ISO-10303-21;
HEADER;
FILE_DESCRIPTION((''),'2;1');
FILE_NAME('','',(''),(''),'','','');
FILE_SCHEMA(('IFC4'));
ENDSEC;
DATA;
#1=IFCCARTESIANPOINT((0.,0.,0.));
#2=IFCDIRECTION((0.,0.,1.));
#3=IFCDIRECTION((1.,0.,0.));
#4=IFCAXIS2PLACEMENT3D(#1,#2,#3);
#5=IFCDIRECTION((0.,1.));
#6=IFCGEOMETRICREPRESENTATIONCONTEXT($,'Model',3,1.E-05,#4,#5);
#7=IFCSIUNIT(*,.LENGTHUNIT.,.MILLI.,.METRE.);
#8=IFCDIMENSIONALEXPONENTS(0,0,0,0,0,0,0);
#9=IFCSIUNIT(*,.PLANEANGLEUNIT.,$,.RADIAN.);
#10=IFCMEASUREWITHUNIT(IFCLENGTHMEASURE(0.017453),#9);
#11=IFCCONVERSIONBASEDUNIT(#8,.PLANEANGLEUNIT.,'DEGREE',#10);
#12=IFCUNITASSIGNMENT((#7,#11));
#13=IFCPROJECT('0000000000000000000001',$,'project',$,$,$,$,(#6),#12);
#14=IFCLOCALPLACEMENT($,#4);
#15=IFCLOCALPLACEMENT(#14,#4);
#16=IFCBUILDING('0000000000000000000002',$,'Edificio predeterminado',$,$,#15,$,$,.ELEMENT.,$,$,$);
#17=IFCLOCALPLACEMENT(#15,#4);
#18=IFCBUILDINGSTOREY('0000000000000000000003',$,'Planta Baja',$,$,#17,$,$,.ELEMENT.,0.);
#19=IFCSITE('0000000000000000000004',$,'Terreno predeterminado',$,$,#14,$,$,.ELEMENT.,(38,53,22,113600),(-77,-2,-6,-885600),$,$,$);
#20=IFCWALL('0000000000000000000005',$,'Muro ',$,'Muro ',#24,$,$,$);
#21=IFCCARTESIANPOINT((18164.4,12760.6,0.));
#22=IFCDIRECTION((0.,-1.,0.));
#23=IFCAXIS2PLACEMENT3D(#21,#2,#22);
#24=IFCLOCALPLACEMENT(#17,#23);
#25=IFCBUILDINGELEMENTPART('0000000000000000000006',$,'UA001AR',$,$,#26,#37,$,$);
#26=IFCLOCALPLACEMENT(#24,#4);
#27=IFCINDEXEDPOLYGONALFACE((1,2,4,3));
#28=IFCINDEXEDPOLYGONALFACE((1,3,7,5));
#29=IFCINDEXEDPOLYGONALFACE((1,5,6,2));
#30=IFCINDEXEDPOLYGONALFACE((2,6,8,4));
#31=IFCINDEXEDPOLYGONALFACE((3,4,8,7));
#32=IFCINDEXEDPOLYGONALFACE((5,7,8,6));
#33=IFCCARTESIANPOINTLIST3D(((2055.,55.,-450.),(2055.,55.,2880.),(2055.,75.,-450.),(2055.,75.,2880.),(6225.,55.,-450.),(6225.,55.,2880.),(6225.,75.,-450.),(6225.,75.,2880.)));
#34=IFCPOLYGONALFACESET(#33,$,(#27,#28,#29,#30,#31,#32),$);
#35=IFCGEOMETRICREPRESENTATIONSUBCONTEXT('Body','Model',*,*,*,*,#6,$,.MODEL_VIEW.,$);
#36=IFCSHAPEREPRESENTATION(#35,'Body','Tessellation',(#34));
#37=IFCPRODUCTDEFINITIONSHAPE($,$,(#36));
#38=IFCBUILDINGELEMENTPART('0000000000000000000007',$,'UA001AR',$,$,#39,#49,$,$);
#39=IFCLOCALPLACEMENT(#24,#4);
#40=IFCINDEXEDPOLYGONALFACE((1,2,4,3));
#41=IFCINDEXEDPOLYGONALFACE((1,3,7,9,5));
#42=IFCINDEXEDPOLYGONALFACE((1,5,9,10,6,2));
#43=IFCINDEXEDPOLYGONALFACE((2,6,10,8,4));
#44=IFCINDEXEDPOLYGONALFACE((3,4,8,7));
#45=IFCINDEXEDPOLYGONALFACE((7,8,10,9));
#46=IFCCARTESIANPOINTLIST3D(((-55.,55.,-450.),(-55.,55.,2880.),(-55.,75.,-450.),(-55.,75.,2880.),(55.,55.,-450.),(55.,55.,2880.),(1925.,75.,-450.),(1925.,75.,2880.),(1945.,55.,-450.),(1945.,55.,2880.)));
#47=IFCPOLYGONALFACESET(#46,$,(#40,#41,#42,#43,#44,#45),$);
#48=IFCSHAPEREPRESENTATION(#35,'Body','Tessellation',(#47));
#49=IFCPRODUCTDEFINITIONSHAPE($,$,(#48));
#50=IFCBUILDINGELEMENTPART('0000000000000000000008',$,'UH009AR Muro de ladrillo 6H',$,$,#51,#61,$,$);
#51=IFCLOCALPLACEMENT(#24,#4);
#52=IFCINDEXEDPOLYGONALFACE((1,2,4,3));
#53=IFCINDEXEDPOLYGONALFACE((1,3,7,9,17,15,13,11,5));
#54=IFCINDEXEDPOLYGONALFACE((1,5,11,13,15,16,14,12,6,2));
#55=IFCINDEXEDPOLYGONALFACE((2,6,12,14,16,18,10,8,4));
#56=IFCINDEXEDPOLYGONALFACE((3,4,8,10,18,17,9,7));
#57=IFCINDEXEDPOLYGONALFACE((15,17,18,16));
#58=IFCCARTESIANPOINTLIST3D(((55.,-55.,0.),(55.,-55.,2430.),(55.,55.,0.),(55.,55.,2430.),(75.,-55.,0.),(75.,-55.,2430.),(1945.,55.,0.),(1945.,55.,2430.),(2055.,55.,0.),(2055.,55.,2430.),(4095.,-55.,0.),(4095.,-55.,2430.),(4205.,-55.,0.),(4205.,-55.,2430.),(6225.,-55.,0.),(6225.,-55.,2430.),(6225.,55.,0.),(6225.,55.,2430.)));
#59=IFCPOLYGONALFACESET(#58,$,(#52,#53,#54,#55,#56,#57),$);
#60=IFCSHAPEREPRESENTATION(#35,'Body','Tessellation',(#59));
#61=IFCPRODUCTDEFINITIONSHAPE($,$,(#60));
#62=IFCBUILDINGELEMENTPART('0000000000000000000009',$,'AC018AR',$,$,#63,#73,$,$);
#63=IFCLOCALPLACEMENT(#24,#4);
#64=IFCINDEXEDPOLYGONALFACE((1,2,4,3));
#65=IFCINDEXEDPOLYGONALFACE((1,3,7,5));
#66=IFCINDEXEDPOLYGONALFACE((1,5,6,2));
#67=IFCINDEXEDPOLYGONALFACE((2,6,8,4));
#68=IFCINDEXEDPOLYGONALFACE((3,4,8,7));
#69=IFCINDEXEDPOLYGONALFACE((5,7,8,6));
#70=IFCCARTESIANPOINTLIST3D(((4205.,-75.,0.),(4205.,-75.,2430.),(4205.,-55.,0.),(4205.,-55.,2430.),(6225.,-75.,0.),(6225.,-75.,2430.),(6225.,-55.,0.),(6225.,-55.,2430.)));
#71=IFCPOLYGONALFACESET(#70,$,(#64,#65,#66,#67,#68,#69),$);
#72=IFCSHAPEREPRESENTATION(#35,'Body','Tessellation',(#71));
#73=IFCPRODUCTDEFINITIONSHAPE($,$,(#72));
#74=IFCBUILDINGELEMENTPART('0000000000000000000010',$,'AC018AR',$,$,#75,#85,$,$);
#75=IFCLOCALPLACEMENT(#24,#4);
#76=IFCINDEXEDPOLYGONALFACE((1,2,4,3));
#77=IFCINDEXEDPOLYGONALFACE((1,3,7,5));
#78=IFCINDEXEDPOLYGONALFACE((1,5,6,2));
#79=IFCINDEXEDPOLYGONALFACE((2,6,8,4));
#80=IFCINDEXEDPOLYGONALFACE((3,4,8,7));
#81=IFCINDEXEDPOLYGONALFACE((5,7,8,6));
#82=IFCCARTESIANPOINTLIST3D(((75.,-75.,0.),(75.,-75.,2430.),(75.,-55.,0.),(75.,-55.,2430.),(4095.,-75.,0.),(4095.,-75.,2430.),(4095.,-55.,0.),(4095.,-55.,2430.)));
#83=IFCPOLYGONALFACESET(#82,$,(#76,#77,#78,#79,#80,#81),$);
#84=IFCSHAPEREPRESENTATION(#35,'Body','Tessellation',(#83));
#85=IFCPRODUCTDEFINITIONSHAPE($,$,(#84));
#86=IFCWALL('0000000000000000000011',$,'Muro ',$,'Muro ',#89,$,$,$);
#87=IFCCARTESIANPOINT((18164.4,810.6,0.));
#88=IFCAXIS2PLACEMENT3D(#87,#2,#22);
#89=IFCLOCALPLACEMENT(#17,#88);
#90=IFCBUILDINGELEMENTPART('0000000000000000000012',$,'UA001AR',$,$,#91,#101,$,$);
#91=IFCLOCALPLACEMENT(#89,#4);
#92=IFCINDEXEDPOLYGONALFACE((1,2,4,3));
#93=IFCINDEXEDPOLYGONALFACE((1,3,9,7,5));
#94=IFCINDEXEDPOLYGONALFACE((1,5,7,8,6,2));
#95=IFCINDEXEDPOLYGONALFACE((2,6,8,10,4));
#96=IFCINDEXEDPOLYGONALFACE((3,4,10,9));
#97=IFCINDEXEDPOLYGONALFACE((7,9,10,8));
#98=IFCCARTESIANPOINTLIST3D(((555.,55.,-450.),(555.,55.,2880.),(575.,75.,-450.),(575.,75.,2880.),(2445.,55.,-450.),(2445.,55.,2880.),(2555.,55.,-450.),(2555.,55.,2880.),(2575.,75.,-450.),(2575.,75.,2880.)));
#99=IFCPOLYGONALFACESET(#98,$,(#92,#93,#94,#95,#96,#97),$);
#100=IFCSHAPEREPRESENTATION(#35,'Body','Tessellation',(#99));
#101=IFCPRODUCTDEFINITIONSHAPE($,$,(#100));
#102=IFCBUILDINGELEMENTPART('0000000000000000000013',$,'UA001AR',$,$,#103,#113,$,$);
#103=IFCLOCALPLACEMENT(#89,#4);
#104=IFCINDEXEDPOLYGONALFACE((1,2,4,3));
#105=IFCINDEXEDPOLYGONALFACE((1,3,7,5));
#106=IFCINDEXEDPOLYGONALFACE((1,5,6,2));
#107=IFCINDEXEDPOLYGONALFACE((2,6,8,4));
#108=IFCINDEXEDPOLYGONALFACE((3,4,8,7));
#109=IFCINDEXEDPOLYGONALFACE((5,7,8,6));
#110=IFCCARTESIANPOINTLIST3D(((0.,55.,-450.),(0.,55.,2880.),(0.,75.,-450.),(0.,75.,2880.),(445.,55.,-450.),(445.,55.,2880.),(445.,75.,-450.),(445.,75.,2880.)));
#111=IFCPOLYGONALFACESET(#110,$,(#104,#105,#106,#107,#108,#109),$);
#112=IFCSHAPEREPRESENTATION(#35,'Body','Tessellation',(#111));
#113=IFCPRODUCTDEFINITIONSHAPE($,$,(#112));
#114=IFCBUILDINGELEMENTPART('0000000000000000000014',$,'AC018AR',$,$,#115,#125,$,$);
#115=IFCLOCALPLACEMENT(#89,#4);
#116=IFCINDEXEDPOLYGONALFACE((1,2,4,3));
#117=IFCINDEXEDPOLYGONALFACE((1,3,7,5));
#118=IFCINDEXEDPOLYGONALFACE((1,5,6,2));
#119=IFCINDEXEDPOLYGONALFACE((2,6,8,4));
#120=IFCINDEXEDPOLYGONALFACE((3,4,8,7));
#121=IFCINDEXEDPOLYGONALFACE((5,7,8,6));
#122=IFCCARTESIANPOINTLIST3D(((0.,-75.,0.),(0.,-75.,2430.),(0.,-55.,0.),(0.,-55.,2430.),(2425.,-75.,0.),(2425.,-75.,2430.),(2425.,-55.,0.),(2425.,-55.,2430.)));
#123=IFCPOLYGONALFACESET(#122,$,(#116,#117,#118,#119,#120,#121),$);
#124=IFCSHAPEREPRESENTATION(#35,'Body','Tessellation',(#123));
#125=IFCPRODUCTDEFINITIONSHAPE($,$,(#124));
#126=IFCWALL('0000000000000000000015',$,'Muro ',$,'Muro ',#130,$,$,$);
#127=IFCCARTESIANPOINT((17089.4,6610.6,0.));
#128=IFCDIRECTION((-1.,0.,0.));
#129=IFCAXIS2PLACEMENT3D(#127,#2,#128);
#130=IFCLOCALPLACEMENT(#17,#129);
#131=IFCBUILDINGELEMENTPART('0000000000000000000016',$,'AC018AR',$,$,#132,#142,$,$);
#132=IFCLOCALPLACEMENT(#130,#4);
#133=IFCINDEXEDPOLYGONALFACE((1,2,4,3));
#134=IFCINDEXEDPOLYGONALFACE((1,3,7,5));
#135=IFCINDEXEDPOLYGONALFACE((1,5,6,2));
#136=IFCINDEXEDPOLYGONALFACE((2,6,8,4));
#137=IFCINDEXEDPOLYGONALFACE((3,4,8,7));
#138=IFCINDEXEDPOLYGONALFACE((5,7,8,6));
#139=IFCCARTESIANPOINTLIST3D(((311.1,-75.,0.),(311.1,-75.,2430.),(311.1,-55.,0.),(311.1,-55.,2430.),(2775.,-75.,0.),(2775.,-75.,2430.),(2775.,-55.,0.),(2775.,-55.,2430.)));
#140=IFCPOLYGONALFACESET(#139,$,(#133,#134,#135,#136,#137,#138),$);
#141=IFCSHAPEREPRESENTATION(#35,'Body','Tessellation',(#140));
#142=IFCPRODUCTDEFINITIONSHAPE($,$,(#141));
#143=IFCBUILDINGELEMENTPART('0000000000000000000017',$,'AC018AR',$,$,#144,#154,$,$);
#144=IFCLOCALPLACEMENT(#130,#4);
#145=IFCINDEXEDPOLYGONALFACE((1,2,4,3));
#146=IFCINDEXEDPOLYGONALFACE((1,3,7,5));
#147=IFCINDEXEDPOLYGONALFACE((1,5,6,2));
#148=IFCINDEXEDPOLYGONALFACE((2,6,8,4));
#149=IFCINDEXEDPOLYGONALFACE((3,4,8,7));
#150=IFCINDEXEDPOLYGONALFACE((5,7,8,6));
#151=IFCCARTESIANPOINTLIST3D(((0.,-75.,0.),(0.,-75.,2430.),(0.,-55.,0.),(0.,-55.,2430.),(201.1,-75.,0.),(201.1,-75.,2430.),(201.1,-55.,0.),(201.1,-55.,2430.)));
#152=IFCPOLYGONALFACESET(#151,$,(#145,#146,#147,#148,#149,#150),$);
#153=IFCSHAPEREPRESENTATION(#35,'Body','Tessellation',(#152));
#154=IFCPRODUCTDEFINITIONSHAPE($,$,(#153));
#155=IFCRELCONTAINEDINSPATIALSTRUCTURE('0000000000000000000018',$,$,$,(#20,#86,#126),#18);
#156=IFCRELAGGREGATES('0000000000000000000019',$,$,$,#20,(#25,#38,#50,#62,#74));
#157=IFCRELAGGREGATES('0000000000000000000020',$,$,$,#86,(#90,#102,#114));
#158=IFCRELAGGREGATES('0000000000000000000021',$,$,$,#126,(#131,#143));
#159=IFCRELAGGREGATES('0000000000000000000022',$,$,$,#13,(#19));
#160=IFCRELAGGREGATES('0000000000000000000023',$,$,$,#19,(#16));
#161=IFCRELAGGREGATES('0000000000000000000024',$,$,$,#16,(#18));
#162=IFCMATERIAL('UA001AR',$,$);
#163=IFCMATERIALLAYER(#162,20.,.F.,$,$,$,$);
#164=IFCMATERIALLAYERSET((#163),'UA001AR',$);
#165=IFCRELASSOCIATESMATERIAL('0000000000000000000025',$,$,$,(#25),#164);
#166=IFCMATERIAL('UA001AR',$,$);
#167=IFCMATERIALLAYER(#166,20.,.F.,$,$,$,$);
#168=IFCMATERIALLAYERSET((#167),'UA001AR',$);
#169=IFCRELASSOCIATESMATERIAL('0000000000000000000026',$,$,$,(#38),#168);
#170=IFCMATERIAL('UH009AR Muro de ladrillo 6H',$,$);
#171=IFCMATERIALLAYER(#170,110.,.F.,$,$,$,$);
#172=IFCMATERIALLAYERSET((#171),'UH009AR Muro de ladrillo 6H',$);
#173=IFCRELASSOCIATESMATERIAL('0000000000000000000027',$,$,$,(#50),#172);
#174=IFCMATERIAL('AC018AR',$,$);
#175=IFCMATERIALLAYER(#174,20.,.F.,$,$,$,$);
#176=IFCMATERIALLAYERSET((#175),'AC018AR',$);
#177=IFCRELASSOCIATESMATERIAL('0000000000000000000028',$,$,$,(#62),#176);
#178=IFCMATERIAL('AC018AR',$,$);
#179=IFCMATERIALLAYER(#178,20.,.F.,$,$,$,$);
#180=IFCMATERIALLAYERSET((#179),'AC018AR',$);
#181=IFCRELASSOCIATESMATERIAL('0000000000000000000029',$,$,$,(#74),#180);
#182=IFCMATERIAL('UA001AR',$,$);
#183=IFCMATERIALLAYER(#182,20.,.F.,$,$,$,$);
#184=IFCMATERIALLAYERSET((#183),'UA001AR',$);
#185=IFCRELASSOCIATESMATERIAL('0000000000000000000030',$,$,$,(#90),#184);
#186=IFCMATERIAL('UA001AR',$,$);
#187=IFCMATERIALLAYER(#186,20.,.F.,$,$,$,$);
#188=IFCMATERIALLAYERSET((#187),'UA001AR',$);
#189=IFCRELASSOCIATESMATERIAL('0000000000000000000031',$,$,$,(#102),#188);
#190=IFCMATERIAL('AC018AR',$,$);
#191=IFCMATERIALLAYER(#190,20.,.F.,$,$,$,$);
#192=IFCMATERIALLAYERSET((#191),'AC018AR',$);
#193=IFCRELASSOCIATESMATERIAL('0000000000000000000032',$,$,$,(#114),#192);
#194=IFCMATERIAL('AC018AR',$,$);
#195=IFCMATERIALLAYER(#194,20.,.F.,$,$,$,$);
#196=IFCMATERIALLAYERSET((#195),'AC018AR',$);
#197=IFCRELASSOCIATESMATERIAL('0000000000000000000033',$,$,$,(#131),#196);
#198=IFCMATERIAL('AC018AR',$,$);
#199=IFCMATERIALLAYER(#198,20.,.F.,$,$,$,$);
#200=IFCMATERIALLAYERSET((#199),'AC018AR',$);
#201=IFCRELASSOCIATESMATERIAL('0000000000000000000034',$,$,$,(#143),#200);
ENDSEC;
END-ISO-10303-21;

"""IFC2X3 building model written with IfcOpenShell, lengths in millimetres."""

from ifc_helpers import new_model, entity, si_unit, converted_unit, direction, frame, origin_with_axes, place, context, subcontext, project, spatial, polyline, outline, extrude, material, layer, layer_set, layer_usage, element, aggregate, save


model = new_model("IFC2X3")

# Units and contexts
model_context = context("Model", 3, precision=1e-05, world=origin_with_axes(), true_north=direction((0.0, 1.0)))
body_context = subcontext(model_context, "Body", "Model", "MODEL_VIEW")
ifc_project = project(units=[si_unit("LENGTHUNIT", "METRE", prefix="MILLI"), converted_unit("PLANEANGLEUNIT", "DEGREE", entity("IfcLengthMeasure", 0.017453), si_unit("PLANEANGLEUNIT", "RADIAN"), dimensions=[0, 0, 0, 0, 0, 0, 0])], contexts=[model_context])

# Site, building, storey
site_placement = place(None, origin_with_axes())
site = spatial("IfcSite", under=ifc_project, at=site_placement, Name="Terreno predeterminado", CompositionType="ELEMENT", RefLatitude=(38, 53, 22, 113600), RefLongitude=(-77, -2, -6, -885600))
building_placement = place(site_placement, origin_with_axes())
building = spatial("IfcBuilding", under=site, at=building_placement, Name="Edificio predeterminado", CompositionType="ELEMENT")
storey_placement = place(building_placement, origin_with_axes())
storey = spatial("IfcBuildingStorey", under=building, at=storey_placement, Name="Planta Baja", CompositionType="ELEMENT", Elevation=0.0)

# Walls, building element parts
wall_1_placement = place(storey_placement, frame((18164.4, 12760.6, 0.0), z_axis=(0.0, 0.0, 1.0), x_axis=(0.0, -1.0, 0.0)))
wall_1 = element("IfcWall", 1, at=wall_1_placement, inside=storey, Name="Muro ", ObjectType="Muro ")
ifc_material_1 = material(Name="UA001AR")
ifc_layer_1 = layer(ifc_material_1, 20.0, ventilated=False)
ifc_layer_set_1 = layer_set([ifc_layer_1], Name="UA001AR")
ifc_layer_usage_1 = layer_usage(ifc_layer_set_1, "AXIS2", "NEGATIVE", -75.0)
building_element_part_1_placement = place(wall_1_placement, origin_with_axes())
building_element_part_1 = element("IfcBuildingElementPart", 2, at=building_element_part_1_placement, material=ifc_layer_usage_1, Name="UA001AR", context=body_context, shape_type="SweptSolid", body=[
    extrude(outline(polyline([(6225.0, 75.0), (6225.0, 55.0), (2055.0, 55.0), (2055.0, 75.0), (6225.0, 75.0)])), frame((0.0, 0.0, -450.0), z_axis=(0.0, 0.0, 1.0), x_axis=(1.0, 0.0, 0.0)), (0.0, 0.0, 1.0), 3330.0),
])
ifc_material_2 = material(Name="UA001AR")
ifc_layer_2 = layer(ifc_material_2, 20.0, ventilated=False)
ifc_layer_set_2 = layer_set([ifc_layer_2], Name="UA001AR")
ifc_layer_usage_2 = layer_usage(ifc_layer_set_2, "AXIS2", "NEGATIVE", -75.0)
building_element_part_2_placement = place(wall_1_placement, origin_with_axes())
building_element_part_2 = element("IfcBuildingElementPart", 3, at=building_element_part_2_placement, material=ifc_layer_usage_2, Name="UA001AR", context=body_context, shape_type="SweptSolid", body=[
    extrude(outline(polyline([(1925.0, 75.0), (1945.0, 55.0), (55.0, 55.0), (-55.0, 55.0), (-55.0, 75.0), (1925.0, 75.0)])), frame((0.0, 0.0, -450.0), z_axis=(0.0, 0.0, 1.0), x_axis=(1.0, 0.0, 0.0)), (0.0, 0.0, 1.0), 3330.0),
])
ifc_material_3 = material(Name="UH009AR Muro de ladrillo 6H")
ifc_layer_3 = layer(ifc_material_3, 110.0, ventilated=False)
ifc_layer_set_3 = layer_set([ifc_layer_3], Name="UH009AR Muro de ladrillo 6H")
ifc_layer_usage_3 = layer_usage(ifc_layer_set_3, "AXIS2", "NEGATIVE", -55.0)
building_element_part_3_placement = place(wall_1_placement, origin_with_axes())
building_element_part_3 = element("IfcBuildingElementPart", 4, at=building_element_part_3_placement, material=ifc_layer_usage_3, Name="UH009AR Muro de ladrillo 6H", context=body_context, shape_type="SweptSolid", body=[
    extrude(outline(polyline([(6225.0, 55.0), (6225.0, -55.0), (4205.0, -55.0), (4095.0, -55.0), (75.0, -55.0), (55.0, -55.0), (55.0, 55.0), (1945.0, 55.0), (2055.0, 55.0), (6225.0, 55.0)])), origin_with_axes(), (0.0, 0.0, 1.0), 2430.0),
])
ifc_material_4 = material(Name="AC018AR")
ifc_layer_4 = layer(ifc_material_4, 20.0, ventilated=False)
ifc_layer_set_4 = layer_set([ifc_layer_4], Name="AC018AR")
ifc_layer_usage_4 = layer_usage(ifc_layer_set_4, "AXIS2", "NEGATIVE", 55.0)
building_element_part_4_placement = place(wall_1_placement, origin_with_axes())
building_element_part_4 = element("IfcBuildingElementPart", 5, at=building_element_part_4_placement, material=ifc_layer_usage_4, Name="AC018AR", context=body_context, shape_type="SweptSolid", body=[
    extrude(outline(polyline([(6225.0, -55.0), (6225.0, -75.0), (4205.0, -75.0), (4205.0, -55.0), (6225.0, -55.0)])), origin_with_axes(), (0.0, 0.0, 1.0), 2430.0),
])
ifc_material_5 = material(Name="AC018AR")
ifc_layer_5 = layer(ifc_material_5, 20.0, ventilated=False)
ifc_layer_set_5 = layer_set([ifc_layer_5], Name="AC018AR")
ifc_layer_usage_5 = layer_usage(ifc_layer_set_5, "AXIS2", "NEGATIVE", 55.0)
building_element_part_5_placement = place(wall_1_placement, origin_with_axes())
building_element_part_5 = element("IfcBuildingElementPart", 6, at=building_element_part_5_placement, material=ifc_layer_usage_5, Name="AC018AR", context=body_context, shape_type="SweptSolid", body=[
    extrude(outline(polyline([(4095.0, -55.0), (4095.0, -75.0), (75.0, -75.0), (75.0, -55.0), (4095.0, -55.0)])), origin_with_axes(), (0.0, 0.0, 1.0), 2430.0),
])
aggregate(wall_1, [building_element_part_1, building_element_part_2, building_element_part_3, building_element_part_4, building_element_part_5])
wall_2_placement = place(storey_placement, frame((18164.4, 810.6, 0.0), z_axis=(0.0, 0.0, 1.0), x_axis=(0.0, -1.0, 0.0)))
wall_2 = element("IfcWall", 7, at=wall_2_placement, inside=storey, Name="Muro ", ObjectType="Muro ")
ifc_material_6 = material(Name="UA001AR")
ifc_layer_6 = layer(ifc_material_6, 20.0, ventilated=False)
ifc_layer_set_6 = layer_set([ifc_layer_6], Name="UA001AR")
ifc_layer_usage_6 = layer_usage(ifc_layer_set_6, "AXIS2", "NEGATIVE", -75.0)
building_element_part_6_placement = place(wall_2_placement, origin_with_axes())
building_element_part_6 = element("IfcBuildingElementPart", 8, at=building_element_part_6_placement, material=ifc_layer_usage_6, Name="UA001AR", context=body_context, shape_type="SweptSolid", body=[
    extrude(outline(polyline([(2575.0, 75.0), (2555.0, 55.0), (2445.0, 55.0), (555.0, 55.0), (575.0, 75.0), (2575.0, 75.0)])), frame((0.0, 0.0, -450.0), z_axis=(0.0, 0.0, 1.0), x_axis=(1.0, 0.0, 0.0)), (0.0, 0.0, 1.0), 3330.0),
])
ifc_material_7 = material(Name="UA001AR")
ifc_layer_7 = layer(ifc_material_7, 20.0, ventilated=False)
ifc_layer_set_7 = layer_set([ifc_layer_7], Name="UA001AR")
ifc_layer_usage_7 = layer_usage(ifc_layer_set_7, "AXIS2", "NEGATIVE", -75.0)
building_element_part_7_placement = place(wall_2_placement, origin_with_axes())
building_element_part_7 = element("IfcBuildingElementPart", 9, at=building_element_part_7_placement, material=ifc_layer_usage_7, Name="UA001AR", context=body_context, shape_type="SweptSolid", body=[
    extrude(outline(polyline([(445.0, 75.0), (445.0, 55.0), (0.0, 55.0), (0.0, 75.0), (445.0, 75.0)])), frame((0.0, 0.0, -450.0), z_axis=(0.0, 0.0, 1.0), x_axis=(1.0, 0.0, 0.0)), (0.0, 0.0, 1.0), 3330.0),
])
ifc_material_8 = material(Name="AC018AR")
ifc_layer_8 = layer(ifc_material_8, 20.0, ventilated=False)
ifc_layer_set_8 = layer_set([ifc_layer_8], Name="AC018AR")
ifc_layer_usage_8 = layer_usage(ifc_layer_set_8, "AXIS2", "NEGATIVE", 55.0)
building_element_part_8_placement = place(wall_2_placement, origin_with_axes())
building_element_part_8 = element("IfcBuildingElementPart", 10, at=building_element_part_8_placement, material=ifc_layer_usage_8, Name="AC018AR", context=body_context, shape_type="SweptSolid", body=[
    extrude(outline(polyline([(2425.0, -55.0), (2425.0, -75.0), (0.0, -75.0), (0.0, -55.0), (2425.0, -55.0)])), origin_with_axes(), (0.0, 0.0, 1.0), 2430.0),
])
aggregate(wall_2, [building_element_part_6, building_element_part_7, building_element_part_8])
wall_3_placement = place(storey_placement, frame((17089.4, 6610.6, 0.0), z_axis=(0.0, 0.0, 1.0), x_axis=(-1.0, 0.0, 0.0)))
wall_3 = element("IfcWall", 11, at=wall_3_placement, inside=storey, Name="Muro ", ObjectType="Muro ")
ifc_material_9 = material(Name="AC018AR")
ifc_layer_9 = layer(ifc_material_9, 20.0, ventilated=False)
ifc_layer_set_9 = layer_set([ifc_layer_9], Name="AC018AR")
ifc_layer_usage_9 = layer_usage(ifc_layer_set_9, "AXIS2", "NEGATIVE", 55.0)
building_element_part_9_placement = place(wall_3_placement, origin_with_axes())
building_element_part_9 = element("IfcBuildingElementPart", 12, at=building_element_part_9_placement, material=ifc_layer_usage_9, Name="AC018AR", context=body_context, shape_type="SweptSolid", body=[
    extrude(outline(polyline([(2775.0, -55.0), (2775.0, -75.0), (311.1, -75.0), (311.1, -55.0), (2775.0, -55.0)])), origin_with_axes(), (0.0, 0.0, 1.0), 2430.0),
])
ifc_material_10 = material(Name="AC018AR")
ifc_layer_10 = layer(ifc_material_10, 20.0, ventilated=False)
ifc_layer_set_10 = layer_set([ifc_layer_10], Name="AC018AR")
ifc_layer_usage_10 = layer_usage(ifc_layer_set_10, "AXIS2", "NEGATIVE", 55.0)
building_element_part_10_placement = place(wall_3_placement, origin_with_axes())
building_element_part_10 = element("IfcBuildingElementPart", 13, at=building_element_part_10_placement, material=ifc_layer_usage_10, Name="AC018AR", context=body_context, shape_type="SweptSolid", body=[
    extrude(outline(polyline([(201.1, -55.0), (201.1, -75.0), (0.0, -75.0), (0.0, -55.0), (201.1, -55.0)])), origin_with_axes(), (0.0, 0.0, 1.0), 2430.0),
])
aggregate(wall_3, [building_element_part_9, building_element_part_10])

save(model, "model.ifc")
